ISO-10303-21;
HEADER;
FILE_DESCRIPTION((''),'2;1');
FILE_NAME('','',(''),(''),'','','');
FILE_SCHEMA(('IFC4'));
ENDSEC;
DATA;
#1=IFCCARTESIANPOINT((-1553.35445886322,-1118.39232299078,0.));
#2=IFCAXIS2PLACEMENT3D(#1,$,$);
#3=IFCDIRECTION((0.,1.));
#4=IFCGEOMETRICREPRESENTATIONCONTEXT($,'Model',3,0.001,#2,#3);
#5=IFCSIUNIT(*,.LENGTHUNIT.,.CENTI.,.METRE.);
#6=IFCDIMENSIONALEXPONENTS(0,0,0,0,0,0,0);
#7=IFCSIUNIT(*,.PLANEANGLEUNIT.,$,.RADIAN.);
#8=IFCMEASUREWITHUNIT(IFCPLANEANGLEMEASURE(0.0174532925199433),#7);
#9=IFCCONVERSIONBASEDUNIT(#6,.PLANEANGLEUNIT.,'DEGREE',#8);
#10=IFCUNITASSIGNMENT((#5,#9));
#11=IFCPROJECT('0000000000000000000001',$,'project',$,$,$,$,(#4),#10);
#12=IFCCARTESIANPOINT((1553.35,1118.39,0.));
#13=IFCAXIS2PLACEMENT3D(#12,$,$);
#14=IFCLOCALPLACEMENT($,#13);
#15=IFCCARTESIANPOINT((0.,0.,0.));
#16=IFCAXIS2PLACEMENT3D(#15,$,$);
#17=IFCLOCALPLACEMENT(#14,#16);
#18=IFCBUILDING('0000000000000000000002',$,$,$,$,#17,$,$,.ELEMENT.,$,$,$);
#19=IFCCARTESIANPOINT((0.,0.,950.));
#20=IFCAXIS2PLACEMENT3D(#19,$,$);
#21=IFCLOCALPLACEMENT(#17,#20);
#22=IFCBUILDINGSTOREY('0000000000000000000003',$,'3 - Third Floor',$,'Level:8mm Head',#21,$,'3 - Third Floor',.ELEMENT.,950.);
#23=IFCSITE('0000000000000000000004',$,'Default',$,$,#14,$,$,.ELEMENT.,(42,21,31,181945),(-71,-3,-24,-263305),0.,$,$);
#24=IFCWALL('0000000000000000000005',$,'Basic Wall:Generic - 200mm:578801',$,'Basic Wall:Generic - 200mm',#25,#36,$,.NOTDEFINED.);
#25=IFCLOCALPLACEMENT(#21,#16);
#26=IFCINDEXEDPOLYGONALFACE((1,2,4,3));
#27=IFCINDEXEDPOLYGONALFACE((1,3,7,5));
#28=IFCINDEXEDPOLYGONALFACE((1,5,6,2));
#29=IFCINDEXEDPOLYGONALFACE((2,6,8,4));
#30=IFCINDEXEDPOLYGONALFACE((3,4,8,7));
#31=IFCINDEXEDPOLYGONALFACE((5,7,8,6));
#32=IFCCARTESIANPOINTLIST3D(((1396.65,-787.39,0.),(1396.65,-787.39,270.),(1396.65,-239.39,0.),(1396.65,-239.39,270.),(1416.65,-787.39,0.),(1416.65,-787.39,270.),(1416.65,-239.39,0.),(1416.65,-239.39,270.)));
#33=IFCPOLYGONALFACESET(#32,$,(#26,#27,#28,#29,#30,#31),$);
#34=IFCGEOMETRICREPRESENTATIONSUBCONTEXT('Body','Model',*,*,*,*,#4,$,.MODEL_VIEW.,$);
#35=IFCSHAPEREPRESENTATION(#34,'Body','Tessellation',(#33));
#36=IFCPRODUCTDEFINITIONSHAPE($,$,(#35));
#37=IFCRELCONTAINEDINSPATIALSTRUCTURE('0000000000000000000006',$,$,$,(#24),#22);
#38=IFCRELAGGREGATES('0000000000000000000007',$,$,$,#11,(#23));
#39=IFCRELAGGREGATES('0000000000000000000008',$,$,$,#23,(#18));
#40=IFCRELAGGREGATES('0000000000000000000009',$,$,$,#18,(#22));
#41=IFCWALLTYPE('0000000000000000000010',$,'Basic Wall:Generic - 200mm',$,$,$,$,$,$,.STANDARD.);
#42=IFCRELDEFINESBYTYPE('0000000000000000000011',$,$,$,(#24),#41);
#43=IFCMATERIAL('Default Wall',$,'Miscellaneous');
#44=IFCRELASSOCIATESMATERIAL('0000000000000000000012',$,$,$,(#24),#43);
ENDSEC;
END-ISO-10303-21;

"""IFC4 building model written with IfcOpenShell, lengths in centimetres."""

from ifc_helpers import new_model, entity, si_unit, converted_unit, direction, frame, origin, place, context, subcontext, project, spatial, indexed_curve, outline, extrude, material, type_object, element, save


model = new_model("IFC4")

# Units and contexts
model_context = context("Model", 3, precision=0.001, world=frame((-1553.35445886322, -1118.39232299078, 0.0)), true_north=direction((0.0, 1.0)))
body_context = subcontext(model_context, "Body", "Model", "MODEL_VIEW")
ifc_project = project(units=[si_unit("LENGTHUNIT", "METRE", prefix="CENTI"), converted_unit("PLANEANGLEUNIT", "DEGREE", entity("IfcPlaneAngleMeasure", 0.0174532925199433), si_unit("PLANEANGLEUNIT", "RADIAN"), dimensions=[0, 0, 0, 0, 0, 0, 0])], contexts=[model_context])

# Site, building, storey
site_placement = place(None, frame((1553.35, 1118.39, 0.0)))
site = spatial("IfcSite", under=ifc_project, at=site_placement, Name="Default", CompositionType="ELEMENT", RefLatitude=(42, 21, 31, 181945), RefLongitude=(-71, -3, -24, -263305), RefElevation=0.0)
building_placement = place(site_placement, origin())
building = spatial("IfcBuilding", under=site, at=building_placement, CompositionType="ELEMENT")
storey_placement = place(building_placement, frame((0.0, 0.0, 950.0)))
storey = spatial("IfcBuildingStorey", under=building, at=storey_placement, Name="3 - Third Floor", ObjectType="Level:8mm Head", LongName="3 - Third Floor", CompositionType="ELEMENT", Elevation=950.0)

# Wall
ifc_material_1 = material(Name="Default Wall", Category="Miscellaneous")
wall_type_1 = type_object("IfcWallType", Name="Basic Wall:Generic - 200mm", PredefinedType="STANDARD")
wall_1_placement = place(storey_placement, frame((1406.65, -239.39, 0.0), z_axis=(0.0, 0.0, 1.0), x_axis=(0.0, -1.0, 0.0)))
element("IfcWall", 1, at=wall_1_placement, inside=storey, type_object=wall_type_1, material=ifc_material_1, Name="Basic Wall:Generic - 200mm:578801", ObjectType="Basic Wall:Generic - 200mm", PredefinedType="NOTDEFINED", context=body_context, shape_type="SweptSolid", body=[
    extrude(outline(indexed_curve([(548.0, 10.0), (0.0, 10.0), (0.0, -10.0), (548.0, -10.0), (548.0, 10.0)], self_intersect=False)), origin(), (0.0, 0.0, 1.0), 270.0),
])

save(model, "model.ifc")
